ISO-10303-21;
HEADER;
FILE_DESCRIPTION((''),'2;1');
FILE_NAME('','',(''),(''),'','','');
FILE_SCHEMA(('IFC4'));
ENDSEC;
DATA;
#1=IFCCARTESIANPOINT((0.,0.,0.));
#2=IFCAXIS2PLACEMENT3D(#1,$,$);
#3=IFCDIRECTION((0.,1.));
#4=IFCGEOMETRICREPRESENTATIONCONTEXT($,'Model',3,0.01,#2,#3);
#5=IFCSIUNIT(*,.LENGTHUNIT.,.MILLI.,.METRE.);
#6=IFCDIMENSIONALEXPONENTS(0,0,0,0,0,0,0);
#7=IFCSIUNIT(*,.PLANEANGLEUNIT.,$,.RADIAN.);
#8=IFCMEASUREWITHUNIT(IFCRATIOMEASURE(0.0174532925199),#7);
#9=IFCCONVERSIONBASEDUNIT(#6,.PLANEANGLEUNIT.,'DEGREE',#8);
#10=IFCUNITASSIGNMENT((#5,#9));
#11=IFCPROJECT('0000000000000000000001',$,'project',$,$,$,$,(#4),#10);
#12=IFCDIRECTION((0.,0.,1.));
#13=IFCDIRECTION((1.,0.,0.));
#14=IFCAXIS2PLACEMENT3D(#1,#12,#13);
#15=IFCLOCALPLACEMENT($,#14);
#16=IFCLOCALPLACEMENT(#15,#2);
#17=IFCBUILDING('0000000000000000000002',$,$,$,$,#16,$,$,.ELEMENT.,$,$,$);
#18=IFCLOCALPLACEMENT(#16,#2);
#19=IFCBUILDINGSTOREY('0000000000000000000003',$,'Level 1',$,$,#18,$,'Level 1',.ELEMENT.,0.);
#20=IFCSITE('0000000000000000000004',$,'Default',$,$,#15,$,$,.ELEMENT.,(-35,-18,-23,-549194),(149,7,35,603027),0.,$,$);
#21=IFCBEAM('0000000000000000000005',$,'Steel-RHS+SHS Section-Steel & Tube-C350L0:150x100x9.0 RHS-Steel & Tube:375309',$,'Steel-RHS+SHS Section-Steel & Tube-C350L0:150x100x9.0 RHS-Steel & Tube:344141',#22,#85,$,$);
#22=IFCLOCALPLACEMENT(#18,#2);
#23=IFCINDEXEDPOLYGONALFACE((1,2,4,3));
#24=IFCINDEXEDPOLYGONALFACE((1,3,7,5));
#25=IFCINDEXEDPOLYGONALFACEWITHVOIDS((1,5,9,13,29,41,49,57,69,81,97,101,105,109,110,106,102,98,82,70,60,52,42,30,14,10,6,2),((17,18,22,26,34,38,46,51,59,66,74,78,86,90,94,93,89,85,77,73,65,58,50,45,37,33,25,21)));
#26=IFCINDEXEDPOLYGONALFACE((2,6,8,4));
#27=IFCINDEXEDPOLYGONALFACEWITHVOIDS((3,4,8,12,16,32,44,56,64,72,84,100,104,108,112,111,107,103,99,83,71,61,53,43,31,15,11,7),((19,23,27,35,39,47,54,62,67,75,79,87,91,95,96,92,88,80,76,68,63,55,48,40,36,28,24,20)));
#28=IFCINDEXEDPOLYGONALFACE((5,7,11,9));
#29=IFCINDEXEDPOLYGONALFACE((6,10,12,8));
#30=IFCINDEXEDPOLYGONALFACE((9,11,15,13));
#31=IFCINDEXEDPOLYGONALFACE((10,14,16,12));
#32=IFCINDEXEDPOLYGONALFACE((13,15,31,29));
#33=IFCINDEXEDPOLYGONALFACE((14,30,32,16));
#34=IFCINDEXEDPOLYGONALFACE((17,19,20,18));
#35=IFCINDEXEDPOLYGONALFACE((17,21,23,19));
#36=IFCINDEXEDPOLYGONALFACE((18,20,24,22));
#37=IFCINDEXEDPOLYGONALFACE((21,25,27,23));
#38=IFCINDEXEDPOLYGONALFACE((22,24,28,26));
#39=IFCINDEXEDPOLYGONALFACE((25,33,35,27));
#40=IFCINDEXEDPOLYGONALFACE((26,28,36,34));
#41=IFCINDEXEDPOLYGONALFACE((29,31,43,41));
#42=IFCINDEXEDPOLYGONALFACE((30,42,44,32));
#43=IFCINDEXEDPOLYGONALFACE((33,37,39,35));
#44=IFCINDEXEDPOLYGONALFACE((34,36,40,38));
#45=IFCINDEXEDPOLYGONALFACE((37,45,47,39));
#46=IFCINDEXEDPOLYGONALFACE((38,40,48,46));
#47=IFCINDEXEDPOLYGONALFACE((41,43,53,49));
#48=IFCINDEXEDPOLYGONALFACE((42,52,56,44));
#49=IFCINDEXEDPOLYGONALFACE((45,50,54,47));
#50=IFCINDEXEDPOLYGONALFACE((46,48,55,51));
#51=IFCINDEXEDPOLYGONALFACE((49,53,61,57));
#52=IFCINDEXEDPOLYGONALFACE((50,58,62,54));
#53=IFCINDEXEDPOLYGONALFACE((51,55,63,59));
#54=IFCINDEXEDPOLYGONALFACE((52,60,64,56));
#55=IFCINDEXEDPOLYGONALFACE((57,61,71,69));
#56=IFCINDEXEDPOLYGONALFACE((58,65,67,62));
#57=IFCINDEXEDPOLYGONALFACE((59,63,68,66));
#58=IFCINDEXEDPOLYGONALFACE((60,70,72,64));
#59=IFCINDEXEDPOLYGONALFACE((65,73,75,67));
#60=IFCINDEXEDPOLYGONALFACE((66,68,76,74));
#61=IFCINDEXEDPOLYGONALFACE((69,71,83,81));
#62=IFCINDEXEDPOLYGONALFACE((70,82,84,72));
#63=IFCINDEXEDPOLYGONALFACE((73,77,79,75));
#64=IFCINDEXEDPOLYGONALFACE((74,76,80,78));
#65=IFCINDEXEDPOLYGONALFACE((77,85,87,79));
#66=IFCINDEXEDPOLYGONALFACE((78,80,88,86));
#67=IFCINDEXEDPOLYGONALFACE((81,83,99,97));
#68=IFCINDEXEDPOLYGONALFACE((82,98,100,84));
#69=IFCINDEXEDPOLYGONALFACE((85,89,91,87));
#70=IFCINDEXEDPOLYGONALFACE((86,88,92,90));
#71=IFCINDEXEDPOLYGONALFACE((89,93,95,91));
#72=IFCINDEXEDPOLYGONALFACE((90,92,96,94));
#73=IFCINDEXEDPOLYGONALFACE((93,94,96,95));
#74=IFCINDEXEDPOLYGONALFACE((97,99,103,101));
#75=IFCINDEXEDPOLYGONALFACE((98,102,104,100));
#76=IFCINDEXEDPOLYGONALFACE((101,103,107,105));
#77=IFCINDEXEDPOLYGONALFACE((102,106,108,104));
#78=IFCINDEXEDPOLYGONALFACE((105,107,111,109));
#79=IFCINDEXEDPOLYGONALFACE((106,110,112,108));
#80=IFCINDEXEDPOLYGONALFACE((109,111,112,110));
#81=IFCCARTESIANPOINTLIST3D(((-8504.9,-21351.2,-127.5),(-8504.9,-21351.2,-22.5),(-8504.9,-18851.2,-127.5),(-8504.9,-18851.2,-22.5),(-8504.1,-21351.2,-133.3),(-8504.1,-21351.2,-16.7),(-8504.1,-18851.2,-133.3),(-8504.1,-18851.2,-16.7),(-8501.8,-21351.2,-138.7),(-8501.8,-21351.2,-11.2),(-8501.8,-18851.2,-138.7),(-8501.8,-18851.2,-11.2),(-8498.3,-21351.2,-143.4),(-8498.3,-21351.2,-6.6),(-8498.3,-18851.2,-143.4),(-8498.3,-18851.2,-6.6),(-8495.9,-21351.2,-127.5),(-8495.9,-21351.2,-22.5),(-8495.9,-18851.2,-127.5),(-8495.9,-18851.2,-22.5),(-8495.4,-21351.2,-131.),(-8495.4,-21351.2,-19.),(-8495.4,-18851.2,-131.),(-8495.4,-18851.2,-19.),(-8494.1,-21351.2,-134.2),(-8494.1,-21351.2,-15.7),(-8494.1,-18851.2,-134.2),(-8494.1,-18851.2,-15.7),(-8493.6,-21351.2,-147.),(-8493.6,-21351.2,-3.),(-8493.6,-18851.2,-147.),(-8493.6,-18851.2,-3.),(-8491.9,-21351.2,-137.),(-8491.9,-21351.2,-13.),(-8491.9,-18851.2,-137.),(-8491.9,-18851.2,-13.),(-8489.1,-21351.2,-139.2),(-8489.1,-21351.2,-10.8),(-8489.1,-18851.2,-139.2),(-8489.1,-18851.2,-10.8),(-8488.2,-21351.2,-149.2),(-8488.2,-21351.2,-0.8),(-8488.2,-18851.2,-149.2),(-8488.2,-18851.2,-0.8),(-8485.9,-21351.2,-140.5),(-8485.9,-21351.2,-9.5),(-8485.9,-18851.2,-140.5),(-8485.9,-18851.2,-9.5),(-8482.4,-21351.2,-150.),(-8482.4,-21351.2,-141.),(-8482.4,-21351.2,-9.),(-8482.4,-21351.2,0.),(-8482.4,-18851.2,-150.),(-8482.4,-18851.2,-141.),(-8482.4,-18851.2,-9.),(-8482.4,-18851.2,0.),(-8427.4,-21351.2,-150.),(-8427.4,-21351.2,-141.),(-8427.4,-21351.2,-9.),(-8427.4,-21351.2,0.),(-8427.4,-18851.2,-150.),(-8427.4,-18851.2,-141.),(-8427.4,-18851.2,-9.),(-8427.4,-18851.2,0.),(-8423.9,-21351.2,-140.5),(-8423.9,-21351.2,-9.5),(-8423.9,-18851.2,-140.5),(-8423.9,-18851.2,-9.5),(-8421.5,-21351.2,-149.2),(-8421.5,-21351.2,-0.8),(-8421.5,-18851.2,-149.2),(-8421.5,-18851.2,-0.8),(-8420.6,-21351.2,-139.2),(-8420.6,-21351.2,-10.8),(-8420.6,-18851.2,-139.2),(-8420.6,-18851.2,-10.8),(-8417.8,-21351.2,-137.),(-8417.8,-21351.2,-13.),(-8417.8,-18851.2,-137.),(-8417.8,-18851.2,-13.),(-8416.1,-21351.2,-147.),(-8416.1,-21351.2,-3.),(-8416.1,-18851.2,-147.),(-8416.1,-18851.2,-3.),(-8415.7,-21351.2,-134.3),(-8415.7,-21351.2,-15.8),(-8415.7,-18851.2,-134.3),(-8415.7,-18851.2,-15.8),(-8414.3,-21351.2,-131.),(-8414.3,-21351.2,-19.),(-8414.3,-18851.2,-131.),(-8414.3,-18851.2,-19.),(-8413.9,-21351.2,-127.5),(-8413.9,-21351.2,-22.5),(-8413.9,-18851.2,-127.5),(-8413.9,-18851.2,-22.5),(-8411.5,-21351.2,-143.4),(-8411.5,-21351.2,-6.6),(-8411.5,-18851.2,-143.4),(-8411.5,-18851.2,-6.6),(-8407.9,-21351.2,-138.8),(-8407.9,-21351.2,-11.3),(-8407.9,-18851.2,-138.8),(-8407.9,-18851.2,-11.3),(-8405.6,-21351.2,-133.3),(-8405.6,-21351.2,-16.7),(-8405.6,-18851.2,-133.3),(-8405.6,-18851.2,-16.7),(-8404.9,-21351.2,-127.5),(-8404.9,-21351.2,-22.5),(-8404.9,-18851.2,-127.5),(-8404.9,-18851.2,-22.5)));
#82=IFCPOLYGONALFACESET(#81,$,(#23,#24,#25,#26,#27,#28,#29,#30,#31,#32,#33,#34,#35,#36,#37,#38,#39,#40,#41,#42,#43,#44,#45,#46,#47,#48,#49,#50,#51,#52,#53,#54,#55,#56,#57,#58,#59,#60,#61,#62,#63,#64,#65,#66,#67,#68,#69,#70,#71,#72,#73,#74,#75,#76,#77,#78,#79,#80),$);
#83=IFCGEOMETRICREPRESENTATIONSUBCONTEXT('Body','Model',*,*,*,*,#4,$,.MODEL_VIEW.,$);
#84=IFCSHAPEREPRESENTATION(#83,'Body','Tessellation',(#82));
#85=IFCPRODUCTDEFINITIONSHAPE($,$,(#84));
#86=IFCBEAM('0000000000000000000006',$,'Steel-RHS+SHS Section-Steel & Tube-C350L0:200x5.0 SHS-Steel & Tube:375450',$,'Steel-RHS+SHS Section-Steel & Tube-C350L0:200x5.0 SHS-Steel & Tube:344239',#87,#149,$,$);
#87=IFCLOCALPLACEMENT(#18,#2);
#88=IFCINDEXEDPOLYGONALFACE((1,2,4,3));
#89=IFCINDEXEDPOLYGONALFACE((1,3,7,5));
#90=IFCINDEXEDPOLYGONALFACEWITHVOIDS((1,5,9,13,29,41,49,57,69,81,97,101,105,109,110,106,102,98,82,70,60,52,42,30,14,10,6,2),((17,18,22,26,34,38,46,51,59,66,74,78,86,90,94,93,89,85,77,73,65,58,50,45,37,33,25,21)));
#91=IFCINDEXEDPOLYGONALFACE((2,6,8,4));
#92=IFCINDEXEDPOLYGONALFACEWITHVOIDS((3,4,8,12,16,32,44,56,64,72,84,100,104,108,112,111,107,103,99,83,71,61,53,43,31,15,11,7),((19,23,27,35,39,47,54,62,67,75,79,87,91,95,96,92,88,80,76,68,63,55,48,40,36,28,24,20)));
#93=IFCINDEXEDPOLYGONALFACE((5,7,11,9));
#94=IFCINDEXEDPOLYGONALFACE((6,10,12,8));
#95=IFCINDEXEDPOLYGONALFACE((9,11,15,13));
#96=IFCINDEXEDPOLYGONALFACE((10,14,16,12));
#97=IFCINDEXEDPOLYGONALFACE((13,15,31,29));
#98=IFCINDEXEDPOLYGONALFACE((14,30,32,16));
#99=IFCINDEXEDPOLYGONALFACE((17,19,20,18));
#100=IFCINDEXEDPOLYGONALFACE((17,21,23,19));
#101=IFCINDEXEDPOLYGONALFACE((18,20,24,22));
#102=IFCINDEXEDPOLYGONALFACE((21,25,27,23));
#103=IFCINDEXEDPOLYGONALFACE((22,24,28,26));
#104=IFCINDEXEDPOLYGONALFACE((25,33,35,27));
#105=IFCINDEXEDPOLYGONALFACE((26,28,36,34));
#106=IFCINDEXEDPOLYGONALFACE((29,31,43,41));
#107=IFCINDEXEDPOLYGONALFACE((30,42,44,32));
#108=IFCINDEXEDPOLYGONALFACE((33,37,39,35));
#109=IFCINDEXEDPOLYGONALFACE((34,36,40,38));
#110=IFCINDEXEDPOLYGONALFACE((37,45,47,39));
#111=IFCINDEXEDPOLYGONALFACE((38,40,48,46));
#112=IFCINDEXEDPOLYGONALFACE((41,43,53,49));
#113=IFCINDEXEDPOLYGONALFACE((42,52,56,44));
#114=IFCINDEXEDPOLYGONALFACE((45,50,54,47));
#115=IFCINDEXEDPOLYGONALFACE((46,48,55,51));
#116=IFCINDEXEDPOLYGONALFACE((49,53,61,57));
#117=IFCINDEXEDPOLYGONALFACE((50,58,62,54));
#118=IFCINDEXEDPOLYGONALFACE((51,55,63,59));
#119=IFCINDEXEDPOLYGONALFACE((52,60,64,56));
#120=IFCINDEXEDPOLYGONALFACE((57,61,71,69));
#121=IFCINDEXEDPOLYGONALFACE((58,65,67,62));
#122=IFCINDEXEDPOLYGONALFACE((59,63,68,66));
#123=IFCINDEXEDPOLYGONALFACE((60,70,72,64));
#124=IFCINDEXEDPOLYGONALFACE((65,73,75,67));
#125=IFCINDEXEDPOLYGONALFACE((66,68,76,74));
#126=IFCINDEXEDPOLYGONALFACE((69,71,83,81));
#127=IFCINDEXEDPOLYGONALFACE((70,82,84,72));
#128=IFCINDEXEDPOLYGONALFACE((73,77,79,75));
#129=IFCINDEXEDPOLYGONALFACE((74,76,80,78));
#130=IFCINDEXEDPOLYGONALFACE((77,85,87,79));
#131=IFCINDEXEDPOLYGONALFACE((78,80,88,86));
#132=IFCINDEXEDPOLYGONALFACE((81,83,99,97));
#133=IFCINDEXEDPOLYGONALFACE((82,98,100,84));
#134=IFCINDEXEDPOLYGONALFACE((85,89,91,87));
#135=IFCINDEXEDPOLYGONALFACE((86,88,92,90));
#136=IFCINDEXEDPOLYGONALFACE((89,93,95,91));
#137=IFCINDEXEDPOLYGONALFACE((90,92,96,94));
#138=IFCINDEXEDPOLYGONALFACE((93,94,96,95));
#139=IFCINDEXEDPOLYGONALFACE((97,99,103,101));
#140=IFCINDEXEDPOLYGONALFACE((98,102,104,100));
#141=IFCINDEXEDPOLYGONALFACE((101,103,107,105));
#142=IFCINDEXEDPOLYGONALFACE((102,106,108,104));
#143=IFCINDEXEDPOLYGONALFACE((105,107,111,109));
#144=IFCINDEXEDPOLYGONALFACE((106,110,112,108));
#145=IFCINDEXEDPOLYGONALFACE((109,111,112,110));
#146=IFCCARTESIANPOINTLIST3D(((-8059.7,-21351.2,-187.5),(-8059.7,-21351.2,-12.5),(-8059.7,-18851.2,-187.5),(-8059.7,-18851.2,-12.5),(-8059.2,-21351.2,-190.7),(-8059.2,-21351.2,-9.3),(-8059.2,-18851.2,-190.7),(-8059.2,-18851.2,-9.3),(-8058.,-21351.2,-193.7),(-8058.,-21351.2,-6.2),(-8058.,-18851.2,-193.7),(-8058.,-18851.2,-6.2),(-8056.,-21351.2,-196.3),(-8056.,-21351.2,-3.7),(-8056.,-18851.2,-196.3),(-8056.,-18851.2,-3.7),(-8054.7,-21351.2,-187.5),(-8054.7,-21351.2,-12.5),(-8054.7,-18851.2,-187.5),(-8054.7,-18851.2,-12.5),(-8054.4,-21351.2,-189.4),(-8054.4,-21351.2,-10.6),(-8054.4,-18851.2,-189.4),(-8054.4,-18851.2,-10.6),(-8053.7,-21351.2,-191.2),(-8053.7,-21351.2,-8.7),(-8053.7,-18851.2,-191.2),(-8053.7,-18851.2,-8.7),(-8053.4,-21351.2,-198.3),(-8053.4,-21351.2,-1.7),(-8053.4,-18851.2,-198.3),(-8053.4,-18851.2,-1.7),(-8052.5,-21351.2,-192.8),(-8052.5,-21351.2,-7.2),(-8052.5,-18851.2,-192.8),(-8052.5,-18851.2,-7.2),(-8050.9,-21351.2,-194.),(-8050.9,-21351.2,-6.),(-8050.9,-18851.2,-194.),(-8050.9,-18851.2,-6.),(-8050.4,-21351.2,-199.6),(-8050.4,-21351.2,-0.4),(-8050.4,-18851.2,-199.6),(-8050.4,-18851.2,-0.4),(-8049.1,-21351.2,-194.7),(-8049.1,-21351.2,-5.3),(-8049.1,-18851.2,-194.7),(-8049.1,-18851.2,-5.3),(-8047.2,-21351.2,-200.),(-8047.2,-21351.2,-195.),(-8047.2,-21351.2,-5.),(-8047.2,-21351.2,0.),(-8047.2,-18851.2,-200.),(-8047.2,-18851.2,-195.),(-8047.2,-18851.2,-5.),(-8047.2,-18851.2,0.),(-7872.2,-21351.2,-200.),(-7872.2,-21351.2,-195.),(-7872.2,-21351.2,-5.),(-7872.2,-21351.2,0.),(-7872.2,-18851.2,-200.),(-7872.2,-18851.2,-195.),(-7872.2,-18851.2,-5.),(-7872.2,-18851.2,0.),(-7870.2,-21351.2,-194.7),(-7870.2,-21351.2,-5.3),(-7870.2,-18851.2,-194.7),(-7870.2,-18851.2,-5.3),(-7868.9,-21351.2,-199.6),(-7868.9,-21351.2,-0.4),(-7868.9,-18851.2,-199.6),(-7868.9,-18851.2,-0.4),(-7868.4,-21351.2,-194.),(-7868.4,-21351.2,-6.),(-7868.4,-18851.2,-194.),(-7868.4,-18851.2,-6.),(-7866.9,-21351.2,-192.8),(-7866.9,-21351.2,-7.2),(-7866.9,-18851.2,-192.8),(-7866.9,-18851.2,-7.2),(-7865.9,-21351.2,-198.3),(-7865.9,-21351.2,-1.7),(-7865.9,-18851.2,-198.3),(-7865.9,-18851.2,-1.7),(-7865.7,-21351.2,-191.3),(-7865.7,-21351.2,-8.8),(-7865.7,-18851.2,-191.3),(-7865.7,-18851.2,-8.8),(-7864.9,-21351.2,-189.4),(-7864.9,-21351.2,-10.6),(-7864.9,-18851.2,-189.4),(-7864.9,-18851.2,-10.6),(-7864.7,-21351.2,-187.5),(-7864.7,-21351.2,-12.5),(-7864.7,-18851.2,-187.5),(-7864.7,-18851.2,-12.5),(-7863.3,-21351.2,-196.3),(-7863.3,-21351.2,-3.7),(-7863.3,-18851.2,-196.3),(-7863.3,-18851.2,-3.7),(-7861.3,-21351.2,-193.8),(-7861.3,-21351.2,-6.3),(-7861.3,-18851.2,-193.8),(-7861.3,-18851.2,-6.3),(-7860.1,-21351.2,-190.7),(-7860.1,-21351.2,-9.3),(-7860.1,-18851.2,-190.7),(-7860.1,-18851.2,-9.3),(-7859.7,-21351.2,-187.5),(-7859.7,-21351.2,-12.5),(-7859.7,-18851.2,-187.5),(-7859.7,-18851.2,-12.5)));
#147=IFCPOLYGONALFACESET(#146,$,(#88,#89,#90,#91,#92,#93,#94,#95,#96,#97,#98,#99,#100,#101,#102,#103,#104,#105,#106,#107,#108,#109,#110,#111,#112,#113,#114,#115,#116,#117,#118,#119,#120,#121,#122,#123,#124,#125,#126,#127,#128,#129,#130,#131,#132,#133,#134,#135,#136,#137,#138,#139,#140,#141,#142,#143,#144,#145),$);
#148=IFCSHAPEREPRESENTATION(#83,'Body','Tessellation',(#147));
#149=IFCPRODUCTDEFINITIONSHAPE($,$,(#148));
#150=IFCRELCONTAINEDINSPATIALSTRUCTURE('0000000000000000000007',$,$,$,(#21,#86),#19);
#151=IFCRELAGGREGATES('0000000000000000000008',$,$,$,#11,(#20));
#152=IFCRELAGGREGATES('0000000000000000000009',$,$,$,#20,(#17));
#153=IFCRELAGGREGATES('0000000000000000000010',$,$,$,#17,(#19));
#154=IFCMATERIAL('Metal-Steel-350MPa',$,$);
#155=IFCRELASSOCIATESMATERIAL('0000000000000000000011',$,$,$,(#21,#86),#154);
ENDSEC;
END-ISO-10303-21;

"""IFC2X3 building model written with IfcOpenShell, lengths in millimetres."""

from ifc_helpers import new_model, entity, si_unit, converted_unit, direction, frame, frame_2d, origin, origin_with_axes, place, context, subcontext, project, spatial, polyline, circle_curve, parameter, trimmed, segment, composite_curve, outline, extrude, material, element, save


model = new_model("IFC2X3")

# Units and contexts
model_context = context("Model", 3, precision=0.01, world=origin(), true_north=direction((0.0, 1.0)))
body_context = subcontext(model_context, "Body", "Model", "MODEL_VIEW")
ifc_project = project(units=[si_unit("LENGTHUNIT", "METRE", prefix="MILLI"), converted_unit("PLANEANGLEUNIT", "DEGREE", entity("IfcRatioMeasure", 0.0174532925199), si_unit("PLANEANGLEUNIT", "RADIAN"), dimensions=[0, 0, 0, 0, 0, 0, 0])], contexts=[model_context])

# Site, building, storey
site_placement = place(None, origin_with_axes())
site = spatial("IfcSite", under=ifc_project, at=site_placement, Name="Default", CompositionType="ELEMENT", RefLatitude=(-35, -18, -23, -549194), RefLongitude=(149, 7, 35, 603027), RefElevation=0.0)
building_placement = place(site_placement, origin())
building = spatial("IfcBuilding", under=site, at=building_placement, CompositionType="ELEMENT")
storey_placement = place(building_placement, origin())
storey = spatial("IfcBuildingStorey", under=building, at=storey_placement, Name="Level 1", LongName="Level 1", CompositionType="ELEMENT", Elevation=0.0)

# Beams
ifc_material = material(Name="Metal-Steel-350MPa")
beam_1_placement = place(storey_placement, frame((-8454.9, -18851.2, 0.0), z_axis=(0.0, 0.0, 1.0), x_axis=(0.0, -1.0, 0.0)))
element("IfcBeam", 1, at=beam_1_placement, inside=storey, material=ifc_material, Name="Steel-RHS+SHS Section-Steel & Tube-C350L0:150x100x9.0 RHS-Steel & Tube:375309", ObjectType="Steel-RHS+SHS Section-Steel & Tube-C350L0:150x100x9.0 RHS-Steel & Tube:344141", context=body_context, shape_type="SweptSolid", body=[
    extrude(outline(composite_curve([segment(trimmed(circle_curve(frame_2d((-27.5, -52.5), x_axis=(1.0, 0.0)), 22.5), [parameter(180.0)], [parameter(270.0)], True, "PARAMETER"), True, "CONTINUOUS"), segment(polyline([(-27.5, -75.0), (27.5, -75.0)]), True, "CONTINUOUS"), segment(trimmed(circle_curve(frame_2d((27.5, -52.5), x_axis=(1.0, 0.0)), 22.5), [parameter(270.0)], [parameter(0.0)], True, "PARAMETER"), True, "CONTINUOUS"), segment(polyline([(50.0, -52.5), (50.0, 52.5)]), True, "CONTINUOUS"), segment(trimmed(circle_curve(frame_2d((27.5, 52.5), x_axis=(1.0, 0.0)), 22.5), [parameter(0.0)], [parameter(90.0)], True, "PARAMETER"), True, "CONTINUOUS"), segment(polyline([(27.5, 75.0), (-27.5, 75.0)]), True, "CONTINUOUS"), segment(trimmed(circle_curve(frame_2d((-27.5, 52.5), x_axis=(1.0, 0.0)), 22.5), [parameter(90.0)], [parameter(180.0)], True, "PARAMETER"), True, "CONTINUOUS"), segment(polyline([(-50.0, 52.5), (-50.0, -52.5)]), True, "CONTINUOUS")], self_intersect=False), holes=[composite_curve([segment(polyline([(27.5, -66.0), (-27.5, -66.0)]), True, "CONTINUOUS"), segment(trimmed(circle_curve(frame_2d((-27.5, -52.5), x_axis=(1.0, 0.0)), 13.5), [parameter(180.0)], [parameter(270.0)], True, "PARAMETER"), False, "CONTINUOUS"), segment(polyline([(-41.0, -52.5), (-41.0, 52.5)]), True, "CONTINUOUS"), segment(trimmed(circle_curve(frame_2d((-27.5, 52.5), x_axis=(1.0, 0.0)), 13.5), [parameter(90.0)], [parameter(180.0)], True, "PARAMETER"), False, "CONTINUOUS"), segment(polyline([(-27.5, 66.0), (27.5, 66.0)]), True, "CONTINUOUS"), segment(trimmed(circle_curve(frame_2d((27.5, 52.5), x_axis=(1.0, 0.0)), 13.5), [parameter(360.0)], [parameter(90.0)], True, "PARAMETER"), False, "CONTINUOUS"), segment(polyline([(41.0, 52.5), (41.0, -52.5)]), True, "CONTINUOUS"), segment(trimmed(circle_curve(frame_2d((27.5, -52.5), x_axis=(1.0, 0.0)), 13.5), [parameter(270.0)], [parameter(0.0)], True, "PARAMETER"), False, "CONTINUOUS")], self_intersect=False)]), frame((0.0, 0.0, -75.0), z_axis=(1.0, 0.0, 0.0), x_axis=(0.0, -1.0, 0.0)), (0.0, 0.0, 1.0), 2500.0),
])
beam_2_placement = place(storey_placement, frame((-7959.7, -18851.2, 0.0), z_axis=(0.0, 0.0, 1.0), x_axis=(0.0, -1.0, 0.0)))
element("IfcBeam", 2, at=beam_2_placement, inside=storey, material=ifc_material, Name="Steel-RHS+SHS Section-Steel & Tube-C350L0:200x5.0 SHS-Steel & Tube:375450", ObjectType="Steel-RHS+SHS Section-Steel & Tube-C350L0:200x5.0 SHS-Steel & Tube:344239", context=body_context, shape_type="SweptSolid", body=[
    extrude(outline(composite_curve([segment(trimmed(circle_curve(frame_2d((-87.5, -87.5), x_axis=(1.0, 0.0)), 12.5), [parameter(180.0)], [parameter(270.0)], True, "PARAMETER"), True, "CONTINUOUS"), segment(polyline([(-87.5, -100.0), (87.5, -100.0)]), True, "CONTINUOUS"), segment(trimmed(circle_curve(frame_2d((87.5, -87.5), x_axis=(1.0, 0.0)), 12.5), [parameter(270.0)], [parameter(0.0)], True, "PARAMETER"), True, "CONTINUOUS"), segment(polyline([(100.0, -87.5), (100.0, 87.5)]), True, "CONTINUOUS"), segment(trimmed(circle_curve(frame_2d((87.5, 87.5), x_axis=(1.0, 0.0)), 12.5), [parameter(0.0)], [parameter(90.0)], True, "PARAMETER"), True, "CONTINUOUS"), segment(polyline([(87.5, 100.0), (-87.5, 100.0)]), True, "CONTINUOUS"), segment(trimmed(circle_curve(frame_2d((-87.5, 87.5), x_axis=(1.0, 0.0)), 12.5), [parameter(90.0)], [parameter(180.0)], True, "PARAMETER"), True, "CONTINUOUS"), segment(polyline([(-100.0, 87.5), (-100.0, -87.5)]), True, "CONTINUOUS")], self_intersect=False), holes=[composite_curve([segment(polyline([(87.5, -95.0), (-87.5, -95.0)]), True, "CONTINUOUS"), segment(trimmed(circle_curve(frame_2d((-87.5, -87.5), x_axis=(1.0, 0.0)), 7.5), [parameter(180.0)], [parameter(270.0)], True, "PARAMETER"), False, "CONTINUOUS"), segment(polyline([(-95.0, -87.5), (-95.0, 87.5)]), True, "CONTINUOUS"), segment(trimmed(circle_curve(frame_2d((-87.5, 87.5), x_axis=(1.0, 0.0)), 7.5), [parameter(90.0)], [parameter(180.0)], True, "PARAMETER"), False, "CONTINUOUS"), segment(polyline([(-87.5, 95.0), (87.5, 95.0)]), True, "CONTINUOUS"), segment(trimmed(circle_curve(frame_2d((87.5, 87.5), x_axis=(1.0, 0.0)), 7.5), [parameter(360.0)], [parameter(90.0)], True, "PARAMETER"), False, "CONTINUOUS"), segment(polyline([(95.0, 87.5), (95.0, -87.5)]), True, "CONTINUOUS"), segment(trimmed(circle_curve(frame_2d((87.5, -87.5), x_axis=(1.0, 0.0)), 7.5), [parameter(270.0)], [parameter(0.0)], True, "PARAMETER"), False, "CONTINUOUS")], self_intersect=False)]), frame((0.0, 0.0, -100.0), z_axis=(1.0, 0.0, 0.0), x_axis=(0.0, -1.0, 0.0)), (0.0, 0.0, 1.0), 2500.0),
])

save(model, "model.ifc")
